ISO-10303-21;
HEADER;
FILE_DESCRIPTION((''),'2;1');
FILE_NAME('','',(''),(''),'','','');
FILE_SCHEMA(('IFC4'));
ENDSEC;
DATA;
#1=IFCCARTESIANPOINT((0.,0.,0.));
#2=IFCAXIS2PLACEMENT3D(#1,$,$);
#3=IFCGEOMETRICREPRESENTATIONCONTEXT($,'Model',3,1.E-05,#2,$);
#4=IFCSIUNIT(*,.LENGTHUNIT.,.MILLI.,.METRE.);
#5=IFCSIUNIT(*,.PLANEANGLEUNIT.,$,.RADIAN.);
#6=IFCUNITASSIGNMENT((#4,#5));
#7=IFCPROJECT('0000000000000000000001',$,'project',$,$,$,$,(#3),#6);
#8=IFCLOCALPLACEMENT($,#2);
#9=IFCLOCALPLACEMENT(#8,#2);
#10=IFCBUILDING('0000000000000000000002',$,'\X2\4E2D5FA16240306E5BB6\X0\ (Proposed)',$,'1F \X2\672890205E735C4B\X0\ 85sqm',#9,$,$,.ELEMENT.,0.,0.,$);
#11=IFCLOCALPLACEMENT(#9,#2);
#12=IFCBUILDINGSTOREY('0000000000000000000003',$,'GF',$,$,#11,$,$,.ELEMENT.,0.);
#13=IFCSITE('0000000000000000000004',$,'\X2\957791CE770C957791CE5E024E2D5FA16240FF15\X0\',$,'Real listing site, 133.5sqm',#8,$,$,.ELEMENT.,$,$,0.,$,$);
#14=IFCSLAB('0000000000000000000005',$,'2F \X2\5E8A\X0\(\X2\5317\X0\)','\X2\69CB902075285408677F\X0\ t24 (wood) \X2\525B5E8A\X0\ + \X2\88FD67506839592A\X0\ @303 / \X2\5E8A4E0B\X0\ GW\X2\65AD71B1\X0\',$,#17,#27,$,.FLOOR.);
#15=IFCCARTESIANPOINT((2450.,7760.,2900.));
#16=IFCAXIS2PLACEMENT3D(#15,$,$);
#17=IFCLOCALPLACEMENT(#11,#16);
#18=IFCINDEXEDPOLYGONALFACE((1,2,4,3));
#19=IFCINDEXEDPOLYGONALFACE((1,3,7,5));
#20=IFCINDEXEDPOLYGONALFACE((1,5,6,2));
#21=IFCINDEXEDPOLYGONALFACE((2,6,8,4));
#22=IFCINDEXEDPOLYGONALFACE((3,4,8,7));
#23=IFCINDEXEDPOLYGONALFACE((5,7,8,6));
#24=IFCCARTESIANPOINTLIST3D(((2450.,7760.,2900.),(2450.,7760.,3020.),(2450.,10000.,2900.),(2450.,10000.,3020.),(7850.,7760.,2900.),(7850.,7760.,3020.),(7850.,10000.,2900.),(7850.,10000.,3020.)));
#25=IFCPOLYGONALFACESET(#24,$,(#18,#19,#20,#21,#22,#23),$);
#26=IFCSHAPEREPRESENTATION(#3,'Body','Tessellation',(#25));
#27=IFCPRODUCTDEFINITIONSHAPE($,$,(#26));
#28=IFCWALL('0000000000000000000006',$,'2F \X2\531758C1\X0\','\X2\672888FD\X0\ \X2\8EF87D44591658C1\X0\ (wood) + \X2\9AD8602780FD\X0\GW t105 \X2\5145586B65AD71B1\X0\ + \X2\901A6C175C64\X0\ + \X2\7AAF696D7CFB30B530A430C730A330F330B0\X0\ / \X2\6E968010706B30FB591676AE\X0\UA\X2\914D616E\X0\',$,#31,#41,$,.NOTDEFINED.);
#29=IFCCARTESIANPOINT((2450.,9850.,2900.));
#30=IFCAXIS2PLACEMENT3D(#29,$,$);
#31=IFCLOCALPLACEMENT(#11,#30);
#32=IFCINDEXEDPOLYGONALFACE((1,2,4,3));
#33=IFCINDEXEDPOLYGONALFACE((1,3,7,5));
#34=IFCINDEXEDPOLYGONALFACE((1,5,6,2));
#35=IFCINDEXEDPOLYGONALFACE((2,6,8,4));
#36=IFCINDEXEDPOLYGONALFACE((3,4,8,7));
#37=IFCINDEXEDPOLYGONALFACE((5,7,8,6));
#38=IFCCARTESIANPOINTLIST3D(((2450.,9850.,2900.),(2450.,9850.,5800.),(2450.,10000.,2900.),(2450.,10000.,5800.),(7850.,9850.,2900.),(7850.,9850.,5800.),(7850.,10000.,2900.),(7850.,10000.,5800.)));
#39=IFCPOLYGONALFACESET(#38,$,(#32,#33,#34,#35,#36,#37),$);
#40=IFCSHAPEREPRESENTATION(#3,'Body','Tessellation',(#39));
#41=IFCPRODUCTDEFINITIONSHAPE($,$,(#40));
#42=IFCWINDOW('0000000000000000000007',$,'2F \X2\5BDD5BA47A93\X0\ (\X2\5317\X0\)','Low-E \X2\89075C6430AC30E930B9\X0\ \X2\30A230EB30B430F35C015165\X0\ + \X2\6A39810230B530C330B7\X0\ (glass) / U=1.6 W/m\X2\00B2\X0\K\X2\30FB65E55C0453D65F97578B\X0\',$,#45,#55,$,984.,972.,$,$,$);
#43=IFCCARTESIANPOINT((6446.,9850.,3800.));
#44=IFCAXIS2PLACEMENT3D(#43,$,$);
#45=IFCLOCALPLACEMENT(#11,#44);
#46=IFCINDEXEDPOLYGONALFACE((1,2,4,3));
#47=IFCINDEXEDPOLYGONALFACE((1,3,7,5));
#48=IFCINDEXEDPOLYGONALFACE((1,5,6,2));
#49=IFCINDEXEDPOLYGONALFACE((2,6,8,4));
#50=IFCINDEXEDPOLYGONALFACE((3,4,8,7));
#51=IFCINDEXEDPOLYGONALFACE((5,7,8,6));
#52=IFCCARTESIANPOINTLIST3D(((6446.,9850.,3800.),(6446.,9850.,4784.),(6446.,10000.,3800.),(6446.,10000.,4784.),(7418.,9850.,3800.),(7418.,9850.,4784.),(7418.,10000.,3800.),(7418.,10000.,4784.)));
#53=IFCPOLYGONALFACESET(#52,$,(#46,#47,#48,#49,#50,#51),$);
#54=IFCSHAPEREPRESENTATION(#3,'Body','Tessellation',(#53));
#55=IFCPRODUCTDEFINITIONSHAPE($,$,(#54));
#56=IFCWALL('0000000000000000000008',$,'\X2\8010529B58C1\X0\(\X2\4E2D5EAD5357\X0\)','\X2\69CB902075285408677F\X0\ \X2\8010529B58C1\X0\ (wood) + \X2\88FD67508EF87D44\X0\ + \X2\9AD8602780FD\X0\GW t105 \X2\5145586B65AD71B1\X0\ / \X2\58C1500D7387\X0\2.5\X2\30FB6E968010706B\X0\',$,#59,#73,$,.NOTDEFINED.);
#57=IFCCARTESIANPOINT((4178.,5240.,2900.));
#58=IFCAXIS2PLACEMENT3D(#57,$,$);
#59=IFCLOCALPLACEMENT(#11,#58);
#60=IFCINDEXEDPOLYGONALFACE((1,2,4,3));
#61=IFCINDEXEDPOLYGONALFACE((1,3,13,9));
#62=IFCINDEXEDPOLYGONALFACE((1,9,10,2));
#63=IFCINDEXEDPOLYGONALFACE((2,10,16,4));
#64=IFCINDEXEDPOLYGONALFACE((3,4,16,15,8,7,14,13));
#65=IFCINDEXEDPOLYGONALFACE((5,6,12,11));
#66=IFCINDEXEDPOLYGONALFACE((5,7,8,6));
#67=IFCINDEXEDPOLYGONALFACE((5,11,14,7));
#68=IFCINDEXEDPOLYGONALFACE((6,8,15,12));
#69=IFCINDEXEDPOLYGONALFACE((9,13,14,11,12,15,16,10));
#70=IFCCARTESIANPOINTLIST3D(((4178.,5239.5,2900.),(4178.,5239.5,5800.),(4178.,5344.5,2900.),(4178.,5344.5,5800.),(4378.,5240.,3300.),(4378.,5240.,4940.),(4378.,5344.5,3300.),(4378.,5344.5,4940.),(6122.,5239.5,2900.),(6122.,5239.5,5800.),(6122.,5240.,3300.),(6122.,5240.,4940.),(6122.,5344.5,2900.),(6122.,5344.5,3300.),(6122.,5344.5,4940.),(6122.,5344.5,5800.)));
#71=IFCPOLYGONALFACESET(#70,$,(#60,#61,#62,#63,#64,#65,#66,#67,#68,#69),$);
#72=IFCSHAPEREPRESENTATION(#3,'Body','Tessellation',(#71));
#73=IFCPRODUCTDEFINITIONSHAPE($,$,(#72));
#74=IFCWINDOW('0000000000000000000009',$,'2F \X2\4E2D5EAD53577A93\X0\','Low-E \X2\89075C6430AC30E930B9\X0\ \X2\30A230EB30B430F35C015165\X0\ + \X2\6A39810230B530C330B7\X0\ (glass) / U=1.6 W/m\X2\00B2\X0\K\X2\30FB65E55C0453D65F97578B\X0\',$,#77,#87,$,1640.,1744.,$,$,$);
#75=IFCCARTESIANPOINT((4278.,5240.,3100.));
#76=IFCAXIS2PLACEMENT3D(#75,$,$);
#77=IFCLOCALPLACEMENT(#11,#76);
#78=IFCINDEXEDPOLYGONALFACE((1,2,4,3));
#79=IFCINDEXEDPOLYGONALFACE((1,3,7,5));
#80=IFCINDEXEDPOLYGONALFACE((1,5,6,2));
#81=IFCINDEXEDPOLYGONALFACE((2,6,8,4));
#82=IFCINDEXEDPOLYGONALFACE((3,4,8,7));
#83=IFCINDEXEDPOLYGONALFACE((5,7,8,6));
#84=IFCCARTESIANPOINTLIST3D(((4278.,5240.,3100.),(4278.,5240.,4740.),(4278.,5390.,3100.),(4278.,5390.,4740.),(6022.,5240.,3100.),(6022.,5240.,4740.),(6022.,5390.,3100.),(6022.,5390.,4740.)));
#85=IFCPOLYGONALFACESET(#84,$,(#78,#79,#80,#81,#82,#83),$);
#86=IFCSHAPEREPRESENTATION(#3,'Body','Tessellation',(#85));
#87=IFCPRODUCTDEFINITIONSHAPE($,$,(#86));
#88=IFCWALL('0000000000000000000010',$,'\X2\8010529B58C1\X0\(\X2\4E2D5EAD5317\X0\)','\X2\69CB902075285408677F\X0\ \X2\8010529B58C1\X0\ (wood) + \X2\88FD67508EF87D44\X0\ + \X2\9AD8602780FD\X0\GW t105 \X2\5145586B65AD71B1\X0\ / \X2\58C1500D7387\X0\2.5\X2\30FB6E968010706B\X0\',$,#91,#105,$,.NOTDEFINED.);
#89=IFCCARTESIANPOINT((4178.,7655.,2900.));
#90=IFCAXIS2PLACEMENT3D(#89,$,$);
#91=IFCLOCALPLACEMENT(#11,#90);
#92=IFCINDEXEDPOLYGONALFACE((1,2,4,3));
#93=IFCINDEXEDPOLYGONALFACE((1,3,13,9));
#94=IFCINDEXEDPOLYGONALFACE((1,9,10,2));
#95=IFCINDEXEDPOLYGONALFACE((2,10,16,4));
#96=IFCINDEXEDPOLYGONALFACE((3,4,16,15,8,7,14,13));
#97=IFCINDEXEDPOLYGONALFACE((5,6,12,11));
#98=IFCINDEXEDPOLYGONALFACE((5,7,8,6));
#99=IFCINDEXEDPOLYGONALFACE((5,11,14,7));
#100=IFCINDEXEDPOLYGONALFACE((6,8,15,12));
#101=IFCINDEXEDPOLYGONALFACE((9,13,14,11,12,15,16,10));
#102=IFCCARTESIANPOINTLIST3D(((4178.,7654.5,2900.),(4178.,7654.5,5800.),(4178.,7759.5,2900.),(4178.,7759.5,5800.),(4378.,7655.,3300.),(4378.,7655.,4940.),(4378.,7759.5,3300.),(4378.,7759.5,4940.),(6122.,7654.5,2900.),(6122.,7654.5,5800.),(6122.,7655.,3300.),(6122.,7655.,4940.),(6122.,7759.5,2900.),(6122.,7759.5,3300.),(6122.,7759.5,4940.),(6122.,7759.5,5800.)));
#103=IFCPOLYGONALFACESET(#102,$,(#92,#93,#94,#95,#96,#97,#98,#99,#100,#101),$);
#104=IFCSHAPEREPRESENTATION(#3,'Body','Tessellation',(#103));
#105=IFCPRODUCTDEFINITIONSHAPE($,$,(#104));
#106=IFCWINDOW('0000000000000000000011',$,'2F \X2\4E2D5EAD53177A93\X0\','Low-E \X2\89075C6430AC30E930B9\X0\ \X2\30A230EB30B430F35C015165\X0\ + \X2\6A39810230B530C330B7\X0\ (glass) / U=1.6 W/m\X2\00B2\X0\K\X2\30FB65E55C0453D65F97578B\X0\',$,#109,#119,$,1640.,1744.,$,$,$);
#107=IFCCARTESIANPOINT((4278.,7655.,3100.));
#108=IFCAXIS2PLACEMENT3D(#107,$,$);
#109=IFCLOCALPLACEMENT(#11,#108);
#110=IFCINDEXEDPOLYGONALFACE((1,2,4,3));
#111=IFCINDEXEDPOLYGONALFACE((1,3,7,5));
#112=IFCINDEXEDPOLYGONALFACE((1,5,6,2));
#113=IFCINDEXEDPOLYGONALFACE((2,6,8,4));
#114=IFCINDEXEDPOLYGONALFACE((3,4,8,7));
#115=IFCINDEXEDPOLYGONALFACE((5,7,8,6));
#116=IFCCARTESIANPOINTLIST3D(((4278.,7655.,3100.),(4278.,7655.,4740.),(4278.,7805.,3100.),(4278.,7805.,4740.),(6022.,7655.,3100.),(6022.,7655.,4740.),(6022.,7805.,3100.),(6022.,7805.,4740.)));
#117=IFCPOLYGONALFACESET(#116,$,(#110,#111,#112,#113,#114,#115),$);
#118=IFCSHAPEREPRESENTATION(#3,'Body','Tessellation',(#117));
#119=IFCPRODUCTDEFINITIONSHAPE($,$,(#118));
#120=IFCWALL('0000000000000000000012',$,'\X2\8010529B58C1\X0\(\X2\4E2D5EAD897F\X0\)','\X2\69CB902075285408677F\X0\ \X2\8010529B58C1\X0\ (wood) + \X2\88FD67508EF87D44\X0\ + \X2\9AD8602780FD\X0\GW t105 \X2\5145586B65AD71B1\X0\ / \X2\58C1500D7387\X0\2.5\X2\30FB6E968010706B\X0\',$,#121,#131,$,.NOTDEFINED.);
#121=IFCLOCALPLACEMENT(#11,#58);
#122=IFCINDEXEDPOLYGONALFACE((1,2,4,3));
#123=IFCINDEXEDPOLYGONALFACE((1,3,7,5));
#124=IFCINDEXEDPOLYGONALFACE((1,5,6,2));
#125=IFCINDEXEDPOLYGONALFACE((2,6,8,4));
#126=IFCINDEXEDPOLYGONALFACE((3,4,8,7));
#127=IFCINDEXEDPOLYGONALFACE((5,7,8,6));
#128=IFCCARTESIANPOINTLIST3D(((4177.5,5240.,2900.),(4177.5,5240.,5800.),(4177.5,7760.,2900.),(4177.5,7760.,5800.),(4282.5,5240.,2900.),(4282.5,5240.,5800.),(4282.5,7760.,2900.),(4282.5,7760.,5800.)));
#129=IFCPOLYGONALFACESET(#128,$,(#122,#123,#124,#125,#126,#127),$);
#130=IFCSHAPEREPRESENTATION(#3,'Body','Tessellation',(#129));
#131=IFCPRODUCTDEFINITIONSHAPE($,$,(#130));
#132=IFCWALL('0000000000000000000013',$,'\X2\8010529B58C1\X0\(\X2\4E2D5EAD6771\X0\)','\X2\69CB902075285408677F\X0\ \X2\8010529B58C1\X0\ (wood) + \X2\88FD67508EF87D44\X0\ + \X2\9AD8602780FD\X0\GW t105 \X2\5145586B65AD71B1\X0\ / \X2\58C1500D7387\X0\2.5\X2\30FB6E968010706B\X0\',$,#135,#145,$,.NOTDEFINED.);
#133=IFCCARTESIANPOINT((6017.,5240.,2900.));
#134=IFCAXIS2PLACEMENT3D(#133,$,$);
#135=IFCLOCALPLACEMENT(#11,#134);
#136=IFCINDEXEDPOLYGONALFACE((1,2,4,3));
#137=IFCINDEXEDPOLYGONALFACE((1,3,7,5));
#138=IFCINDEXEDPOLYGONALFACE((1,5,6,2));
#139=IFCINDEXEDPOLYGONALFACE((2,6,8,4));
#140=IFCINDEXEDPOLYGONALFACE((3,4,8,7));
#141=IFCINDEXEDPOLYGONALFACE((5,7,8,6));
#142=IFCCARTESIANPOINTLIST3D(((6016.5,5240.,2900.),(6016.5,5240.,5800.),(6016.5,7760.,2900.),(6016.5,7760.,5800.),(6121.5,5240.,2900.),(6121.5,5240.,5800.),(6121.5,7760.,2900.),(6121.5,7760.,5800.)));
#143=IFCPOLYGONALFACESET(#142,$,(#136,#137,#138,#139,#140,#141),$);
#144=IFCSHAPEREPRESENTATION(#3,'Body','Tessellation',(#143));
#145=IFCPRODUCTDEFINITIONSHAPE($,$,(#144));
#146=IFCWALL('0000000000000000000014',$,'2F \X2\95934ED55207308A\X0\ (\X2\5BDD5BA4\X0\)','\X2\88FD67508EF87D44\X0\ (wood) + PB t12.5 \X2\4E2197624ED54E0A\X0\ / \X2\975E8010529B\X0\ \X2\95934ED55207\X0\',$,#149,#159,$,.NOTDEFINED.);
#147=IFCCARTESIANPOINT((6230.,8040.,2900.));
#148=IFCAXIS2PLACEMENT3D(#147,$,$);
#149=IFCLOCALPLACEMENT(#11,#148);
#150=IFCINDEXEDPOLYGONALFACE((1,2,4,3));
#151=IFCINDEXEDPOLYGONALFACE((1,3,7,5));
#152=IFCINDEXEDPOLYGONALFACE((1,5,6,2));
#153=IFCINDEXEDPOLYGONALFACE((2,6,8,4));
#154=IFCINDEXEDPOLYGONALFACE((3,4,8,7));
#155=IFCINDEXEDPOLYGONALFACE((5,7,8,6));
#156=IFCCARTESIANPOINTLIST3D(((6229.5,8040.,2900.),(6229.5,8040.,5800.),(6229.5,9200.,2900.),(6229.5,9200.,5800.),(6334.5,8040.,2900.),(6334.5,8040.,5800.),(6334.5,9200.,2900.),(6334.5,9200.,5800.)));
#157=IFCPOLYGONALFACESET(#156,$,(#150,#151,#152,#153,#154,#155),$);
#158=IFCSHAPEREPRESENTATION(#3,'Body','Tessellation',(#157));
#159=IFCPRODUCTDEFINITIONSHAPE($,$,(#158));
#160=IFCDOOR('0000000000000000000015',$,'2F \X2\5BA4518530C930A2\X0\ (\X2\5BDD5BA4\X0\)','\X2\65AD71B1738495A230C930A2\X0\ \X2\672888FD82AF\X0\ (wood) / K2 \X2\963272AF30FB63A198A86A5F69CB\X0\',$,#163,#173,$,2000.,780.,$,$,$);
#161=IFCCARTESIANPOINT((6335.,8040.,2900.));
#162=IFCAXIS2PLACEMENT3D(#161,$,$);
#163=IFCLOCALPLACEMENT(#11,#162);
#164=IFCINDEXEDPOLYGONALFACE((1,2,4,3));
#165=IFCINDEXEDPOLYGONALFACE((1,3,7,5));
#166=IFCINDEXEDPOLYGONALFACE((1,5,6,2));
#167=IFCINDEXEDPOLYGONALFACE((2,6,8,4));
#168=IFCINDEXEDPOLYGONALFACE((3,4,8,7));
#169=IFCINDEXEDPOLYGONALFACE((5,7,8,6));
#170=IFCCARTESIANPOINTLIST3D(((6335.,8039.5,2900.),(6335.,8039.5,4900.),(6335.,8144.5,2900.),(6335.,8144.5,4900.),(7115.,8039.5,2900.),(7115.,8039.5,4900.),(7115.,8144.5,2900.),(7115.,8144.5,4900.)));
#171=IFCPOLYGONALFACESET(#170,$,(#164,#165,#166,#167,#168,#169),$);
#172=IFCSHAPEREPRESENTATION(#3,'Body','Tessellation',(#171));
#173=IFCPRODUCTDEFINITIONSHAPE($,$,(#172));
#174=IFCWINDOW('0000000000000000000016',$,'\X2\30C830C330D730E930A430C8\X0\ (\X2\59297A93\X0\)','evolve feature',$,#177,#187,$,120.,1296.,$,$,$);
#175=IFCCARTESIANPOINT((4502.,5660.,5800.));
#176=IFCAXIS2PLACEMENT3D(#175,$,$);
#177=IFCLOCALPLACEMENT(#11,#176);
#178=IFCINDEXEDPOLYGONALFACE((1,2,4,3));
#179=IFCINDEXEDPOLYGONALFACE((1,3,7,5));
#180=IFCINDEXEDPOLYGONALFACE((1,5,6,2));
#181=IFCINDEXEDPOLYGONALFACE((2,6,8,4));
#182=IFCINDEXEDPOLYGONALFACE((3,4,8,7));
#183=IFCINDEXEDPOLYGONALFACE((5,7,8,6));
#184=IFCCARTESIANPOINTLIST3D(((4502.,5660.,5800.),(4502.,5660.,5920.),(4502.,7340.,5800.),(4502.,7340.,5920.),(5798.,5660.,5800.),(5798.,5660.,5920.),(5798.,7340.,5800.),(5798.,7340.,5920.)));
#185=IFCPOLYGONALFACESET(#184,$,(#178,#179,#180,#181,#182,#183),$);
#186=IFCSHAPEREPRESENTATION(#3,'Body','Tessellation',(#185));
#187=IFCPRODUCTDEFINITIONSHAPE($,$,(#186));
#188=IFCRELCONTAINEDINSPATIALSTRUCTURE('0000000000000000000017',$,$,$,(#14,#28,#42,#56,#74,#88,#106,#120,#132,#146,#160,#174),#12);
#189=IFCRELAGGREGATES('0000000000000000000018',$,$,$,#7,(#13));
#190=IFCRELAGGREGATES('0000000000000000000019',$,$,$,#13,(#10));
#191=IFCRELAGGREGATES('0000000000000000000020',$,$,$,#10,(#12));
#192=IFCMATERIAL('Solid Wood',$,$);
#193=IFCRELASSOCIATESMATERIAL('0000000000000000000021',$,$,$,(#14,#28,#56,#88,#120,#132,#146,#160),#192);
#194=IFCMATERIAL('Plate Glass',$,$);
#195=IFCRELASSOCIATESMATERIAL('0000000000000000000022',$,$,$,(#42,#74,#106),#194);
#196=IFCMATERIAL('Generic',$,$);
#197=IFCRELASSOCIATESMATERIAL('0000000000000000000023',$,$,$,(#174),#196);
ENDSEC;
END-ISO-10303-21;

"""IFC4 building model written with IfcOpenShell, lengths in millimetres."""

from ifc_helpers import new_model, si_unit, frame, frame_2d, origin, place, context, project, spatial, rectangle, extrude, material, element, fill, save


model = new_model("IFC4")

# Units and contexts
model_context = context("Model", 3, precision=1e-05, world=origin())
ifc_project = project(units=[si_unit("LENGTHUNIT", "METRE", prefix="MILLI"), si_unit("PLANEANGLEUNIT", "RADIAN")], contexts=[model_context])

# Site, building, storey
site_placement = place(None, origin())
site = spatial("IfcSite", under=ifc_project, at=site_placement, Name="長野県長野市中御所５", ObjectType="Real listing site, 133.5sqm", CompositionType="ELEMENT", RefElevation=0.0)
building_placement = place(site_placement, origin())
building = spatial("IfcBuilding", under=site, at=building_placement, Name="中御所の家 (Proposed)", ObjectType="1F 木造平屋 85sqm", CompositionType="ELEMENT", ElevationOfRefHeight=0.0, ElevationOfTerrain=0.0)
storey_placement = place(building_placement, origin())
storey = spatial("IfcBuildingStorey", under=building, at=storey_placement, Name="GF", CompositionType="ELEMENT", Elevation=0.0)

# Slab
ifc_material_1 = material(Name="Solid Wood")
slab_placement = place(storey_placement, frame((2450.0, 7760.0, 2900.0)))
element("IfcSlab", 1, at=slab_placement, inside=storey, material=ifc_material_1, Name="2F 床(北)", Description="構造用合板 t24 (wood) 剛床 + 製材根太 @303 / 床下 GW断熱", PredefinedType="FLOOR", context=model_context, shape_type="SweptSolid", body=[
    extrude(rectangle(XDim=5400.0, YDim=2240.0, at=frame_2d((2700.0, 1120.0))), frame((2450.0, 7760.0, 2900.0)), (0.0, 0.0, 1.0), 120.0),
])

# Walls, openings, windows
wall_1_placement = place(storey_placement, frame((2450.0, 9850.0, 2900.0)))
wall_1 = element("IfcWall", 2, at=wall_1_placement, inside=storey, material=ifc_material_1, Name="2F 北壁", Description="木製 軸組外壁 (wood) + 高性能GW t105 充填断熱 + 通気層 + 窯業系サイディング / 準耐火・外皮UA配慮", PredefinedType="NOTDEFINED", context=model_context, shape_type="SweptSolid", body=[
    extrude(rectangle(XDim=5400.0, YDim=150.0, at=frame_2d((2700.0, 75.0))), frame((2450.0, 9850.0, 2900.0)), (0.0, 0.0, 1.0), 2900.0),
])
opening_1_placement = place(storey_placement, frame((6446.0, 9850.0, 3800.0)))
opening_1 = element("IfcOpeningElement", 3, at=opening_1_placement, cuts=wall_1, PredefinedType="NOTDEFINED", context=model_context, shape_type="SweptSolid", body=[
    extrude(rectangle(XDim=972.0, YDim=150.0, at=frame_2d((486.0, 75.0))), frame((6446.0, 9850.0, 3800.0)), (0.0, 0.0, 1.0), 984.0),
])
ifc_material_2 = material(Name="Plate Glass")
window_1_placement = place(storey_placement, frame((6446.0, 9850.0, 3800.0)))
window_1 = element("IfcWindow", 4, at=window_1_placement, inside=storey, material=ifc_material_2, Name="2F 寝室窓 (北)", Description="Low-E 複層ガラス アルゴン封入 + 樹脂サッシ (glass) / U=1.6 W/m²K・日射取得型", OverallHeight=984.0, OverallWidth=972.0, context=model_context, shape_type="SweptSolid", body=[
    extrude(rectangle(XDim=972.0, YDim=150.0, at=frame_2d((486.0, 75.0))), frame((6446.0, 9850.0, 3800.0)), (0.0, 0.0, 1.0), 984.0),
])
fill(opening_1, window_1)
wall_2_placement = place(storey_placement, frame((4178.0, 5240.0, 2900.0)))
wall_2 = element("IfcWall", 5, at=wall_2_placement, inside=storey, material=ifc_material_1, Name="耐力壁(中庭南)", Description="構造用合板 耐力壁 (wood) + 製材軸組 + 高性能GW t105 充填断熱 / 壁倍率2.5・準耐火", PredefinedType="NOTDEFINED", context=model_context, shape_type="SweptSolid", body=[
    extrude(rectangle(XDim=1944.0, YDim=105.0, at=frame_2d((972.0, 52.0))), frame((4178.0, 5240.0, 2900.0)), (0.0, 0.0, 1.0), 2900.0),
])
opening_2_placement = place(storey_placement, frame((4278.0, 5240.0, 3100.0)))
opening_2 = element("IfcOpeningElement", 6, at=opening_2_placement, cuts=wall_2, PredefinedType="NOTDEFINED", context=model_context, shape_type="SweptSolid", body=[
    extrude(rectangle(XDim=1744.0, YDim=150.0, at=frame_2d((872.0, 75.0))), frame((4278.0, 5240.0, 3100.0)), (0.0, 0.0, 1.0), 1640.0),
])
window_2_placement = place(storey_placement, frame((4278.0, 5240.0, 3100.0)))
window_2 = element("IfcWindow", 7, at=window_2_placement, inside=storey, material=ifc_material_2, Name="2F 中庭南窓", Description="Low-E 複層ガラス アルゴン封入 + 樹脂サッシ (glass) / U=1.6 W/m²K・日射取得型", OverallHeight=1640.0, OverallWidth=1744.0, context=model_context, shape_type="SweptSolid", body=[
    extrude(rectangle(XDim=1744.0, YDim=150.0, at=frame_2d((872.0, 75.0))), frame((4278.0, 5240.0, 3100.0)), (0.0, 0.0, 1.0), 1640.0),
])
fill(opening_2, window_2)
wall_3_placement = place(storey_placement, frame((4178.0, 7655.0, 2900.0)))
wall_3 = element("IfcWall", 8, at=wall_3_placement, inside=storey, material=ifc_material_1, Name="耐力壁(中庭北)", Description="構造用合板 耐力壁 (wood) + 製材軸組 + 高性能GW t105 充填断熱 / 壁倍率2.5・準耐火", PredefinedType="NOTDEFINED", context=model_context, shape_type="SweptSolid", body=[
    extrude(rectangle(XDim=1944.0, YDim=105.0, at=frame_2d((972.0, 52.0))), frame((4178.0, 7655.0, 2900.0)), (0.0, 0.0, 1.0), 2900.0),
])
opening_3_placement = place(storey_placement, frame((4278.0, 7655.0, 3100.0)))
opening_3 = element("IfcOpeningElement", 9, at=opening_3_placement, cuts=wall_3, PredefinedType="NOTDEFINED", context=model_context, shape_type="SweptSolid", body=[
    extrude(rectangle(XDim=1744.0, YDim=150.0, at=frame_2d((872.0, 75.0))), frame((4278.0, 7655.0, 3100.0)), (0.0, 0.0, 1.0), 1640.0),
])
window_3_placement = place(storey_placement, frame((4278.0, 7655.0, 3100.0)))
window_3 = element("IfcWindow", 10, at=window_3_placement, inside=storey, material=ifc_material_2, Name="2F 中庭北窓", Description="Low-E 複層ガラス アルゴン封入 + 樹脂サッシ (glass) / U=1.6 W/m²K・日射取得型", OverallHeight=1640.0, OverallWidth=1744.0, context=model_context, shape_type="SweptSolid", body=[
    extrude(rectangle(XDim=1744.0, YDim=150.0, at=frame_2d((872.0, 75.0))), frame((4278.0, 7655.0, 3100.0)), (0.0, 0.0, 1.0), 1640.0),
])
fill(opening_3, window_3)

# Walls
wall_4_placement = place(storey_placement, frame((4178.0, 5240.0, 2900.0)))
element("IfcWall", 11, at=wall_4_placement, inside=storey, material=ifc_material_1, Name="耐力壁(中庭西)", Description="構造用合板 耐力壁 (wood) + 製材軸組 + 高性能GW t105 充填断熱 / 壁倍率2.5・準耐火", PredefinedType="NOTDEFINED", context=model_context, shape_type="SweptSolid", body=[
    extrude(rectangle(XDim=105.0, YDim=2520.0, at=frame_2d((52.0, 1260.0))), frame((4178.0, 5240.0, 2900.0)), (0.0, 0.0, 1.0), 2900.0),
])
wall_5_placement = place(storey_placement, frame((6017.0, 5240.0, 2900.0)))
element("IfcWall", 12, at=wall_5_placement, inside=storey, material=ifc_material_1, Name="耐力壁(中庭東)", Description="構造用合板 耐力壁 (wood) + 製材軸組 + 高性能GW t105 充填断熱 / 壁倍率2.5・準耐火", PredefinedType="NOTDEFINED", context=model_context, shape_type="SweptSolid", body=[
    extrude(rectangle(XDim=105.0, YDim=2520.0, at=frame_2d((52.0, 1260.0))), frame((6017.0, 5240.0, 2900.0)), (0.0, 0.0, 1.0), 2900.0),
])
wall_6_placement = place(storey_placement, frame((6230.0, 8040.0, 2900.0)))
element("IfcWall", 13, at=wall_6_placement, inside=storey, material=ifc_material_1, Name="2F 間仕切り (寝室)", Description="製材軸組 (wood) + PB t12.5 両面仕上 / 非耐力 間仕切", PredefinedType="NOTDEFINED", context=model_context, shape_type="SweptSolid", body=[
    extrude(rectangle(XDim=105.0, YDim=1160.0, at=frame_2d((52.0, 580.0))), frame((6230.0, 8040.0, 2900.0)), (0.0, 0.0, 1.0), 2900.0),
])

# Door
door_placement = place(storey_placement, frame((6335.0, 8040.0, 2900.0)))
element("IfcDoor", 14, at=door_placement, inside=storey, material=ifc_material_1, Name="2F 室内ドア (寝室)", Description="断熱玄関ドア 木製芯 (wood) / K2 防犯・採風機構", OverallHeight=2000.0, OverallWidth=780.0, context=model_context, shape_type="SweptSolid", body=[
    extrude(rectangle(XDim=780.0, YDim=105.0, at=frame_2d((390.0, 52.0))), frame((6335.0, 8040.0, 2900.0)), (0.0, 0.0, 1.0), 2000.0),
])

# Window
ifc_material_3 = material(Name="Generic")
window_4_placement = place(storey_placement, frame((4502.0, 5660.0, 5800.0)))
element("IfcWindow", 15, at=window_4_placement, inside=storey, material=ifc_material_3, Name="トップライト (天窓)", Description="evolve feature", OverallHeight=120.0, OverallWidth=1296.0, context=model_context, shape_type="SweptSolid", body=[
    extrude(rectangle(XDim=1296.0, YDim=1680.0, at=frame_2d((648.0, 840.0))), frame((4502.0, 5660.0, 5800.0)), (0.0, 0.0, 1.0), 120.0),
])

save(model, "model.ifc")
